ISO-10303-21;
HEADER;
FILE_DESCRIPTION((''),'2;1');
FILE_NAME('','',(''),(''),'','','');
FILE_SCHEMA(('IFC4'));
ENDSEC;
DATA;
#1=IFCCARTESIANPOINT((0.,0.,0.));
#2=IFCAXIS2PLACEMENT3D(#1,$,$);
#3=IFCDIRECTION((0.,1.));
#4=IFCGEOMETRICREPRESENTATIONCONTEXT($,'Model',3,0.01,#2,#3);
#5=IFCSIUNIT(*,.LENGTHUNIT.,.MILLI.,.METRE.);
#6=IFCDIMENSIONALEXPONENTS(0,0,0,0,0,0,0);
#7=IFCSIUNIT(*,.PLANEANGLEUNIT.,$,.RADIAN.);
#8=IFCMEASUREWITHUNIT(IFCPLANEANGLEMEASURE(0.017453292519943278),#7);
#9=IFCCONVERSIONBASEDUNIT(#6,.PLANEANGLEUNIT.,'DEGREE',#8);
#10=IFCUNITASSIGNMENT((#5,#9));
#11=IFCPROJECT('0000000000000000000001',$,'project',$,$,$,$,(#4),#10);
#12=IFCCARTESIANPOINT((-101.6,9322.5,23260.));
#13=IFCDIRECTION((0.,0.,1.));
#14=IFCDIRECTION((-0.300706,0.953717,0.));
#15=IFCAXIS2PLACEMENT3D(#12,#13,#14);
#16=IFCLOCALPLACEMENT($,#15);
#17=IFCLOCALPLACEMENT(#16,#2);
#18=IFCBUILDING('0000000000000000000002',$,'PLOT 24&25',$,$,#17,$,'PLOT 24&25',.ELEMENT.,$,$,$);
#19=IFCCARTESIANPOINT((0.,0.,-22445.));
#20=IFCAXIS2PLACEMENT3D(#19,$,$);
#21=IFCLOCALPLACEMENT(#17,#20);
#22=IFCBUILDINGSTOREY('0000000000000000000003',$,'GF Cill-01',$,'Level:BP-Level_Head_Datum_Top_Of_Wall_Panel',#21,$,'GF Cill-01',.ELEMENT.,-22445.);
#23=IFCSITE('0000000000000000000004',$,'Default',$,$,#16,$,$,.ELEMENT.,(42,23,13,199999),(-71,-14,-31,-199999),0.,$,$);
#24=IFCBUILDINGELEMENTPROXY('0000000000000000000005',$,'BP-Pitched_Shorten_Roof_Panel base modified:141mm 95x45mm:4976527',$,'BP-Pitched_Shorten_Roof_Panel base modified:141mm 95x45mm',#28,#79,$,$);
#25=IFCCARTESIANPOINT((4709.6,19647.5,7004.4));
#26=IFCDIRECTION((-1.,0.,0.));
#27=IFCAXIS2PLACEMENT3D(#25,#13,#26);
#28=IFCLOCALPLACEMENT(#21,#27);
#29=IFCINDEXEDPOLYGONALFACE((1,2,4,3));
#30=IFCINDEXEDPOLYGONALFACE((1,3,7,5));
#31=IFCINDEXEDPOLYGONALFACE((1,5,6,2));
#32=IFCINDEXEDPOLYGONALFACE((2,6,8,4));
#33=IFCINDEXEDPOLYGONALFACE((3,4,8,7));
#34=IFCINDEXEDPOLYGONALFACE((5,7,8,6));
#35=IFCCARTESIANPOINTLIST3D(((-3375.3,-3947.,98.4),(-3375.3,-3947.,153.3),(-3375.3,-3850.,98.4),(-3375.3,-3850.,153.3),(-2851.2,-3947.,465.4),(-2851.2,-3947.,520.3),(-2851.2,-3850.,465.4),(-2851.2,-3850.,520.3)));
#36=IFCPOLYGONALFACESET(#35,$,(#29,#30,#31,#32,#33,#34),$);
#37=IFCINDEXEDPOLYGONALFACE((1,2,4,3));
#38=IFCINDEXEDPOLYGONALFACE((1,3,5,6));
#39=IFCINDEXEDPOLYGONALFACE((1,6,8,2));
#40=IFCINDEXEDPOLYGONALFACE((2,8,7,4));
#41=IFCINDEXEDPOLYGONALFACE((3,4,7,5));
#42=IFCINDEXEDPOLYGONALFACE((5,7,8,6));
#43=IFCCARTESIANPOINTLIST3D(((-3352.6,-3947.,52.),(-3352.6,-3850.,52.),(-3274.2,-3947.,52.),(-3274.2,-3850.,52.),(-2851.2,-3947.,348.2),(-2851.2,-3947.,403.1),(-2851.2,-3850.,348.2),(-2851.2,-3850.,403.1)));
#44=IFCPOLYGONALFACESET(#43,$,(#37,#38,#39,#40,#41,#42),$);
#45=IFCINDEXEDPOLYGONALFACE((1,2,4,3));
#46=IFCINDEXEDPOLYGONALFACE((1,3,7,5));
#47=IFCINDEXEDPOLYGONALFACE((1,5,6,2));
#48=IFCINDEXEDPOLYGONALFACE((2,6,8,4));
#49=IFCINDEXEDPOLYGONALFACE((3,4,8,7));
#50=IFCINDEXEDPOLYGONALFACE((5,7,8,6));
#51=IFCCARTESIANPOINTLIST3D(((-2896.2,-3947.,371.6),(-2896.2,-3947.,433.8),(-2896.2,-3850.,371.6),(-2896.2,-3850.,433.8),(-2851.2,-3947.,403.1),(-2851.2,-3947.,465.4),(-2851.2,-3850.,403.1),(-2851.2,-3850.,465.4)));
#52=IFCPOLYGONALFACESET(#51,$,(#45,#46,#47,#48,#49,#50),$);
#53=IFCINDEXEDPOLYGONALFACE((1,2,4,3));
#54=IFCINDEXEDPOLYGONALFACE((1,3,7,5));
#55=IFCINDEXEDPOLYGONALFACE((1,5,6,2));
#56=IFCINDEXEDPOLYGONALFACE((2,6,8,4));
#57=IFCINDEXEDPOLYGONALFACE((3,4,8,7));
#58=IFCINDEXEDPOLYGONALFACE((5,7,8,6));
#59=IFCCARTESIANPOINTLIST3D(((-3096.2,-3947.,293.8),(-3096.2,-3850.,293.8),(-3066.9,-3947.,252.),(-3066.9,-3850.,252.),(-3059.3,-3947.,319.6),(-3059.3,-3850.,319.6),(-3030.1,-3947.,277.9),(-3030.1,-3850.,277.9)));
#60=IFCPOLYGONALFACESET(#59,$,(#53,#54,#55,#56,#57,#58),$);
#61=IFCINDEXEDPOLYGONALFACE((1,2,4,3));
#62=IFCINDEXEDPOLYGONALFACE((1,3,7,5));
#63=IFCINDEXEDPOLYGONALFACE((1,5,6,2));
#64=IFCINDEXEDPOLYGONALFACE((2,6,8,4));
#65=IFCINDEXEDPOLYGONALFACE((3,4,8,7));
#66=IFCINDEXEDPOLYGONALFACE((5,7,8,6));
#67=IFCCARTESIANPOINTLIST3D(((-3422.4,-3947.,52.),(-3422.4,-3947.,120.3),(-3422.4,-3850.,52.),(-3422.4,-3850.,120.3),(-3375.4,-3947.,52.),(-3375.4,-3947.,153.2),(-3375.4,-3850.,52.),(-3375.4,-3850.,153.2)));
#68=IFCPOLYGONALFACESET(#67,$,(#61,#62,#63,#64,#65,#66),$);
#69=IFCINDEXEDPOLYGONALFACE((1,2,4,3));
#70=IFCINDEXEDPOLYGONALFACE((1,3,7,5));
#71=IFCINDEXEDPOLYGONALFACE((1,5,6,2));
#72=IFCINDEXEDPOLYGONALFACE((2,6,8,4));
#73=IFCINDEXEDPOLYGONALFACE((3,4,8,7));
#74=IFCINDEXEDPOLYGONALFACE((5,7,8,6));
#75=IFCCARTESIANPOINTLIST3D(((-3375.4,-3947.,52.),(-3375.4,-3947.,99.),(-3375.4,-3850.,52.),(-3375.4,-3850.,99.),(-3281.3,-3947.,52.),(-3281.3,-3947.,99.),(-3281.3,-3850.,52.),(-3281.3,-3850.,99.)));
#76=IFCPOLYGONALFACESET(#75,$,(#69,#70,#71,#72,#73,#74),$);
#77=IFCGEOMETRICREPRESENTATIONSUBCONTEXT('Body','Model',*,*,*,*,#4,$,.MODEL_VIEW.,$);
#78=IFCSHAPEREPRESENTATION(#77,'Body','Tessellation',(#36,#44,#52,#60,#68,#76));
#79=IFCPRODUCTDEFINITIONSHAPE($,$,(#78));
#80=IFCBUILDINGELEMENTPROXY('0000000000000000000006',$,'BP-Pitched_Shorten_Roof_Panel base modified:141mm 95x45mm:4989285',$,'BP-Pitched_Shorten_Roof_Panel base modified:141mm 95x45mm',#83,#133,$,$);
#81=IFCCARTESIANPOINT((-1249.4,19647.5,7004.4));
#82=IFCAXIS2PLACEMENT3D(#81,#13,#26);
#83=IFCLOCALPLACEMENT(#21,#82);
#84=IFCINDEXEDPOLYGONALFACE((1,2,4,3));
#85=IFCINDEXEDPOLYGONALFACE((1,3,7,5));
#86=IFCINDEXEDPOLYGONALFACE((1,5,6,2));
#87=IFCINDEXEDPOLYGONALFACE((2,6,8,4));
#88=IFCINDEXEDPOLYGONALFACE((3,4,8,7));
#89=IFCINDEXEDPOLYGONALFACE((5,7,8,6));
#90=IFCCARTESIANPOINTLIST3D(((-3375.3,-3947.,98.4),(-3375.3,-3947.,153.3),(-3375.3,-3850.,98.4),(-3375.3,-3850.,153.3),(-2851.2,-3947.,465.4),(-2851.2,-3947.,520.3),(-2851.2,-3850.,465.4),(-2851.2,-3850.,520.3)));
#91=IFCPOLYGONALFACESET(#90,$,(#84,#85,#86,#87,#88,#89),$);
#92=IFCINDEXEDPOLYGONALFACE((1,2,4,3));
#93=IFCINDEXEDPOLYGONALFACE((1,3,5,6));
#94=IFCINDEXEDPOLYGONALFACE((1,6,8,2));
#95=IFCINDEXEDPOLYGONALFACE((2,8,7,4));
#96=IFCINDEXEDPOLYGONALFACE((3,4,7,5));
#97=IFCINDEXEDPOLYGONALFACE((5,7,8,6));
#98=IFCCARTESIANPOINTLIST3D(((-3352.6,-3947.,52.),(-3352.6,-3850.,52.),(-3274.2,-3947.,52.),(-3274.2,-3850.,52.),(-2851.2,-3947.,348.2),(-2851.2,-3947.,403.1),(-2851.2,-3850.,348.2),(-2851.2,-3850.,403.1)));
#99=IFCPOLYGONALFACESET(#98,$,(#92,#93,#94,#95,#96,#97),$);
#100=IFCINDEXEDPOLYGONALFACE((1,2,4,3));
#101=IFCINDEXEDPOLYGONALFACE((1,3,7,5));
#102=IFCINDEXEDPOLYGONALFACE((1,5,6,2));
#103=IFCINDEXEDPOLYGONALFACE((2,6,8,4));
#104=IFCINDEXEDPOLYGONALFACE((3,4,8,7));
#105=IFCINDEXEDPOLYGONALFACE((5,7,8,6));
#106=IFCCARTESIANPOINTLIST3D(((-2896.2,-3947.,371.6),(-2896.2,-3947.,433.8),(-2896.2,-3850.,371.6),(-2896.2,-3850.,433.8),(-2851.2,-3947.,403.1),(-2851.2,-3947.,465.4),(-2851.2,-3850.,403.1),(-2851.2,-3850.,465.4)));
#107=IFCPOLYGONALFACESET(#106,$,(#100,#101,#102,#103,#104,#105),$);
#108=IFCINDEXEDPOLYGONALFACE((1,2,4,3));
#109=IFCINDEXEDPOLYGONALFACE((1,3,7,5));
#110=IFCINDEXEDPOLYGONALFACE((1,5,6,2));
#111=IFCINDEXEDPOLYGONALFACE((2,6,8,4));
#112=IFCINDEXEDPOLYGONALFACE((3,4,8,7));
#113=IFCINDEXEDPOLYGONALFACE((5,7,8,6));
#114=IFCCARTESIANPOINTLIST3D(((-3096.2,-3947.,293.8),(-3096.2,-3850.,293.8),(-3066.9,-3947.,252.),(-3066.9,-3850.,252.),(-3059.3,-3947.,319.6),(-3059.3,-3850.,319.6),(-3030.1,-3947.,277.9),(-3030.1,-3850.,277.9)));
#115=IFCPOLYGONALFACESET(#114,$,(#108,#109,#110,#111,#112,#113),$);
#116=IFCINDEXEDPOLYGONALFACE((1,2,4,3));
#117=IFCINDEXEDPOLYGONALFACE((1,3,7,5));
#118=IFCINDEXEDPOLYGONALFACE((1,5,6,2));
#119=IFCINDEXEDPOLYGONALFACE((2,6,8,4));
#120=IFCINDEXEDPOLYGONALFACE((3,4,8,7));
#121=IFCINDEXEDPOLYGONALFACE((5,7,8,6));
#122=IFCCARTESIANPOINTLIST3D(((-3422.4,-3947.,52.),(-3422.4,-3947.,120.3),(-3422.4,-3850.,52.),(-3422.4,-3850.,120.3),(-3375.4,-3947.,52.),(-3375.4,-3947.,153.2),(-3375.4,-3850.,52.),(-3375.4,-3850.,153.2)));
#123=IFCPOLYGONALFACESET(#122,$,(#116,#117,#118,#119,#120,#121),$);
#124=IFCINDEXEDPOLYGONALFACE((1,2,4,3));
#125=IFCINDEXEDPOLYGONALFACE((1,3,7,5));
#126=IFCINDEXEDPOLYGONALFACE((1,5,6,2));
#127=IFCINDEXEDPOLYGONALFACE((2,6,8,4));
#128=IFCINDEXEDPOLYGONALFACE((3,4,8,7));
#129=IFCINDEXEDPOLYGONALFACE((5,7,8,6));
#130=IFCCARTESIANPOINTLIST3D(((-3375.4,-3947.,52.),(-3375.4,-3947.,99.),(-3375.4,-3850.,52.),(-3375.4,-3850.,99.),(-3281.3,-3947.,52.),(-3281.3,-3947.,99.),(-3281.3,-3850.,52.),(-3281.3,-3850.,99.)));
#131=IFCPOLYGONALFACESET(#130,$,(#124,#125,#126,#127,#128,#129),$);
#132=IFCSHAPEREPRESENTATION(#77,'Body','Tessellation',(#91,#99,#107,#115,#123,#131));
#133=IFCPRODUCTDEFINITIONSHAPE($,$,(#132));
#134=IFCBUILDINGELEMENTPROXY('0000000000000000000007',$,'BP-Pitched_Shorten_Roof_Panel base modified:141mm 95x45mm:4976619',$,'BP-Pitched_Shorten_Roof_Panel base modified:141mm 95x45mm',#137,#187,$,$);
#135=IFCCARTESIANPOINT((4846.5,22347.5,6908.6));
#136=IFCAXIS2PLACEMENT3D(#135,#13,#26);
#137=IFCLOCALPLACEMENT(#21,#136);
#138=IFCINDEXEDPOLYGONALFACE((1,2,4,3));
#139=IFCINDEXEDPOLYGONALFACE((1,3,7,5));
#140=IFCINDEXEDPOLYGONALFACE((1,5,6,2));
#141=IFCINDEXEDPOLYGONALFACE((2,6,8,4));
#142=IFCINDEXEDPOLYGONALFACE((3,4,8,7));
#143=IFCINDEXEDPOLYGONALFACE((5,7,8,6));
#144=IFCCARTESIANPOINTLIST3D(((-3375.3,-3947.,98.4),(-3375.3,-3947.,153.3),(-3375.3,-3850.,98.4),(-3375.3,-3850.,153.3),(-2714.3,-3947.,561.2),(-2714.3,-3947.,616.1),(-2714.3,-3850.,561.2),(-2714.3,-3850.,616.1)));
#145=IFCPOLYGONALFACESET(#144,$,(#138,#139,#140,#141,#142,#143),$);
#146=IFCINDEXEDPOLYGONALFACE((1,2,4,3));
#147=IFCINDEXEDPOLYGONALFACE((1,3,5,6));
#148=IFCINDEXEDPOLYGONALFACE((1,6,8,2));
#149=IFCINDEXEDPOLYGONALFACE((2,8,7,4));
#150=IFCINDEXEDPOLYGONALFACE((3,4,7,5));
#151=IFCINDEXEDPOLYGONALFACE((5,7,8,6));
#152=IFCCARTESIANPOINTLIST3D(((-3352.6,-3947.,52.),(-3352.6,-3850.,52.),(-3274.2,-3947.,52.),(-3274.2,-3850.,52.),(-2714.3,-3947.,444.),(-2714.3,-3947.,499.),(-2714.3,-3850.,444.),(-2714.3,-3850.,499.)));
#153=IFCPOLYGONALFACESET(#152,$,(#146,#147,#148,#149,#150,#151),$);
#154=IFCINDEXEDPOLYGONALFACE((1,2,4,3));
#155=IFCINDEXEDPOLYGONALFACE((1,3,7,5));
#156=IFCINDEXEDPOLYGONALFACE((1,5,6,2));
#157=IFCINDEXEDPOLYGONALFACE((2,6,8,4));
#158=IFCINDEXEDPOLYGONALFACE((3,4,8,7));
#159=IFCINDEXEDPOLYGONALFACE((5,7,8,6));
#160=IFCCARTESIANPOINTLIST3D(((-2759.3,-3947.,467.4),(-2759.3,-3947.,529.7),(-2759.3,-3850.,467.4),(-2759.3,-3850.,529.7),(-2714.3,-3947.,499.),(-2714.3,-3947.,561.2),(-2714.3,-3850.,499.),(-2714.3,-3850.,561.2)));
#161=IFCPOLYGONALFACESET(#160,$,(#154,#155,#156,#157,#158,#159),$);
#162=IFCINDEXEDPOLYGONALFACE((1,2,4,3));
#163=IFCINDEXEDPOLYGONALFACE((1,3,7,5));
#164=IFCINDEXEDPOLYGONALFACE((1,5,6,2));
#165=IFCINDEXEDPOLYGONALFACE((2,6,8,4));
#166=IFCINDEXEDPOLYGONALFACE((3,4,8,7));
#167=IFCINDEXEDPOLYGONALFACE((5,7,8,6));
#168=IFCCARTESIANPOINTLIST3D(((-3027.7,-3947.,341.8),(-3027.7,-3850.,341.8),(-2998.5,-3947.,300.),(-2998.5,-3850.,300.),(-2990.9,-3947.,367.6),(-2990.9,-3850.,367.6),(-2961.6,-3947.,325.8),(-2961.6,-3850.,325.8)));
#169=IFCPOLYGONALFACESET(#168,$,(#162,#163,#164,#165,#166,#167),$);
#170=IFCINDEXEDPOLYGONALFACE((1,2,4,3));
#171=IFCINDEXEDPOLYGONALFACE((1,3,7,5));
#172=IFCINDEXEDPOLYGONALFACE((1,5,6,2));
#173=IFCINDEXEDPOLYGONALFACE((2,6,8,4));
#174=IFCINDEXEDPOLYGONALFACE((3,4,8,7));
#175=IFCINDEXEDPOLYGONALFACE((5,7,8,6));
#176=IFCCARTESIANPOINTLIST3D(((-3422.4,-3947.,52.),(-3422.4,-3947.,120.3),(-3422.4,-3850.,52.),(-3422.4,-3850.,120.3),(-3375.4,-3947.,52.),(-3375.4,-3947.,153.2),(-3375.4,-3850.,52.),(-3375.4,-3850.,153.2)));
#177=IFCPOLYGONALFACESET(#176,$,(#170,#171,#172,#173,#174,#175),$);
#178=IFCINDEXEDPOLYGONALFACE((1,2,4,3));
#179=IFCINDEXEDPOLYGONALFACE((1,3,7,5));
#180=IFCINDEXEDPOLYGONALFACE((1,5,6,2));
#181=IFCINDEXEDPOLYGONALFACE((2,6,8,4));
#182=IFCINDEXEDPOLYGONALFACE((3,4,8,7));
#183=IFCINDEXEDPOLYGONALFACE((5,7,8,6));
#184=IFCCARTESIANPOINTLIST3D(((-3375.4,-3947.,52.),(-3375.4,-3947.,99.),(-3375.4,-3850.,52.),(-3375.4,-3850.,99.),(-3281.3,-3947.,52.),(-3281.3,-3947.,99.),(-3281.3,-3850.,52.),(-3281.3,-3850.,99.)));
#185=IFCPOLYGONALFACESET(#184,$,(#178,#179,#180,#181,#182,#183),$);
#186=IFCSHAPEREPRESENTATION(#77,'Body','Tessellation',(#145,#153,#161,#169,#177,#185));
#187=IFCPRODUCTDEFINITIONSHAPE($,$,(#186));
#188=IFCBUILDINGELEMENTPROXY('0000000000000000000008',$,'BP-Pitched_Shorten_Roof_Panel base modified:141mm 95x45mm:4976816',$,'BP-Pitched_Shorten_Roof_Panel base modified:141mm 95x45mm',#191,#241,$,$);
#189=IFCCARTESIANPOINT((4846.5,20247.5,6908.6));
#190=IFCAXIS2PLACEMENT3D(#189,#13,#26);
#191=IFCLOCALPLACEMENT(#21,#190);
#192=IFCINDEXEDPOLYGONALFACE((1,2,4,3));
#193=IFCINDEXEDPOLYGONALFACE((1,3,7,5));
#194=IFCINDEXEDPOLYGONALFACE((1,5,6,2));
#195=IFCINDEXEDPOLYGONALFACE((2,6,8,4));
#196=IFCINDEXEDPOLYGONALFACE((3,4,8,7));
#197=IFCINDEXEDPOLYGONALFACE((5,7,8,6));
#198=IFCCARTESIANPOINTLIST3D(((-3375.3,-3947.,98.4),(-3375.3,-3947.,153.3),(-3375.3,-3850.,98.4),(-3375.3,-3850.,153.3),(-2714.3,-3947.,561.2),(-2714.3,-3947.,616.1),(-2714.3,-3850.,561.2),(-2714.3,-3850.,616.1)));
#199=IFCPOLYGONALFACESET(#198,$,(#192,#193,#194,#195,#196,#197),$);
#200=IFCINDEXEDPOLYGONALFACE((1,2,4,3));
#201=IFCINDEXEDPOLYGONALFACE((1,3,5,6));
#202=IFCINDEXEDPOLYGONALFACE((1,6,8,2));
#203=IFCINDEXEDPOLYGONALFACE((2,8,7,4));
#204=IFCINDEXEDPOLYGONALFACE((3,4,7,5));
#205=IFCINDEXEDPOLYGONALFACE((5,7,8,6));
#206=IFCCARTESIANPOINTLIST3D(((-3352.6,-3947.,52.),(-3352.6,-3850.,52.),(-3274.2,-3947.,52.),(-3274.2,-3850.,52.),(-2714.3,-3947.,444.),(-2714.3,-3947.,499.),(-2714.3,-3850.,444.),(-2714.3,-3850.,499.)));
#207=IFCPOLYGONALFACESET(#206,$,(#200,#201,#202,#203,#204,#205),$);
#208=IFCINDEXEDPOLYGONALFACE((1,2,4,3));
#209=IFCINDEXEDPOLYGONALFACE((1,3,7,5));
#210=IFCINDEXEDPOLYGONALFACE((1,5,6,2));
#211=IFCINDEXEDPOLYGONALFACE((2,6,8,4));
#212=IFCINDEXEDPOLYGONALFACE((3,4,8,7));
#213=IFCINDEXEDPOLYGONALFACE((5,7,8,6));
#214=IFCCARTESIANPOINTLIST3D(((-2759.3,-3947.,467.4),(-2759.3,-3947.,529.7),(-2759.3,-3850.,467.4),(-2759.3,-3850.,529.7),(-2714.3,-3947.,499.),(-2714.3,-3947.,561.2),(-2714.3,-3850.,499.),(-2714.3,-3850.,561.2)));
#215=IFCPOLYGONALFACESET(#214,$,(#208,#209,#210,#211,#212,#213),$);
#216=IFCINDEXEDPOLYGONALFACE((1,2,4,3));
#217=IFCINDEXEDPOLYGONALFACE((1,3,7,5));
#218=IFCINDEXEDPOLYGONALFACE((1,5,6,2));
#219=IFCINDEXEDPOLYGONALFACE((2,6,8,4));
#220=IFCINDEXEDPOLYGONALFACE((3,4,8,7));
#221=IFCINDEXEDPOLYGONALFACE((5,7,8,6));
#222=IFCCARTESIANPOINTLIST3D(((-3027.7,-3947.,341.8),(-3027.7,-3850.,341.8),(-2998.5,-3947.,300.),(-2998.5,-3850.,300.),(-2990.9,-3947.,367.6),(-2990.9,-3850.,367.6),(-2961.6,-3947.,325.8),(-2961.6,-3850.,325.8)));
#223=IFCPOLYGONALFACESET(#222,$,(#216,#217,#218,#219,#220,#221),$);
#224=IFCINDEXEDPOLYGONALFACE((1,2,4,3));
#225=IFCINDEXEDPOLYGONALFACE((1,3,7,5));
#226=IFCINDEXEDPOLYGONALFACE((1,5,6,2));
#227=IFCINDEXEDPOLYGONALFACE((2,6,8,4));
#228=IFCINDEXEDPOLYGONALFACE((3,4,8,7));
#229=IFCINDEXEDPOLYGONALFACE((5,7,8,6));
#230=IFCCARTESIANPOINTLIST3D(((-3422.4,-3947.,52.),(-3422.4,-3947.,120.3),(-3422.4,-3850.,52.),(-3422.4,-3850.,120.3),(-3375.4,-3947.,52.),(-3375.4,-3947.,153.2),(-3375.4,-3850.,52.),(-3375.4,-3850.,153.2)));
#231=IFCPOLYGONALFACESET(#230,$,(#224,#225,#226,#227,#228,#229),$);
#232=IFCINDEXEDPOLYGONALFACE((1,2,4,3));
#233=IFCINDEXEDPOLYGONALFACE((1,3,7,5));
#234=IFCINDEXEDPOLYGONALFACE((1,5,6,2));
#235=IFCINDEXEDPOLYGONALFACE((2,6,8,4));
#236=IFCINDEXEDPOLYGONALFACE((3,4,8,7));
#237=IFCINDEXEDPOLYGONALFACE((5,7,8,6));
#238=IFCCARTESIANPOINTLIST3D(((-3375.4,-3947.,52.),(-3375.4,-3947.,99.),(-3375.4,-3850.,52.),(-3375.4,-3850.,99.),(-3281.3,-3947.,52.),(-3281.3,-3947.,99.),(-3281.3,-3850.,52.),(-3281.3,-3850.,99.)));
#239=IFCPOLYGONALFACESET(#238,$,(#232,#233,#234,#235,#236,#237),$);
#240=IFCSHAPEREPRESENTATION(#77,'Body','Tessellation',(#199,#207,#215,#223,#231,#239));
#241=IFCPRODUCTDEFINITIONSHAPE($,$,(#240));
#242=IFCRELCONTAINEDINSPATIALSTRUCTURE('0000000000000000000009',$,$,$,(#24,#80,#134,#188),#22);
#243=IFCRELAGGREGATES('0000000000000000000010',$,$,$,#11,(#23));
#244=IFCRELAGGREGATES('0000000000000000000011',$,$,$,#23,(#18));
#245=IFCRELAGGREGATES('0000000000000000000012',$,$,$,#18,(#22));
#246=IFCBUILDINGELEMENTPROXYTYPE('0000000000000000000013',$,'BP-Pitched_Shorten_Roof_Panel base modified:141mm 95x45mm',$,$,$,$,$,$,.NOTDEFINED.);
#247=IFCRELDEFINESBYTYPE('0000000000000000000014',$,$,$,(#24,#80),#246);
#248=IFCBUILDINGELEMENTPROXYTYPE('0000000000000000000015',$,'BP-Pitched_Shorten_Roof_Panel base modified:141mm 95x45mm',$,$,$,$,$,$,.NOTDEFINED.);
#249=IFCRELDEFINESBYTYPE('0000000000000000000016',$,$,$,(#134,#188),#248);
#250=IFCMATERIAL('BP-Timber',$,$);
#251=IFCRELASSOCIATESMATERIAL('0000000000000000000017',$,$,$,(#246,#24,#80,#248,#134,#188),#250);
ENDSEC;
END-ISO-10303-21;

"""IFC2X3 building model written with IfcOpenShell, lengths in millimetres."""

from ifc_helpers import new_model, entity, si_unit, converted_unit, direction, frame, frame_2d, origin, origin_2d_with_axis, place, context, subcontext, project, spatial, polyline, rectangle, outline, extrude, source, transform, mapped, material, type_object, type_shapes, element, save


model = new_model("IFC2X3")

# Units and contexts
model_context = context("Model", 3, precision=0.01, world=origin(), true_north=direction((0.0, 1.0)))
body_context = subcontext(model_context, "Body", "Model", "MODEL_VIEW")
ifc_project = project(units=[si_unit("LENGTHUNIT", "METRE", prefix="MILLI"), converted_unit("PLANEANGLEUNIT", "DEGREE", entity("IfcPlaneAngleMeasure", 0.017453292519943278), si_unit("PLANEANGLEUNIT", "RADIAN"), dimensions=[0, 0, 0, 0, 0, 0, 0])], contexts=[model_context])

# Site, building, storey
site_placement = place(None, frame((-101.6, 9322.5, 23260.0), z_axis=(0.0, 0.0, 1.0), x_axis=(-0.300706, 0.953717, 0.0)))
site = spatial("IfcSite", under=ifc_project, at=site_placement, Name="Default", CompositionType="ELEMENT", RefLatitude=(42, 23, 13, 199999), RefLongitude=(-71, -14, -31, -199999), RefElevation=0.0)
building_placement = place(site_placement, origin())
building = spatial("IfcBuilding", under=site, at=building_placement, Name="PLOT 24&25", LongName="PLOT 24&25", CompositionType="ELEMENT")
storey_placement = place(building_placement, frame((0.0, 0.0, -22445.0)))
storey = spatial("IfcBuildingStorey", under=building, at=storey_placement, Name="GF Cill-01", ObjectType="Level:BP-Level_Head_Datum_Top_Of_Wall_Panel", LongName="GF Cill-01", CompositionType="ELEMENT", Elevation=-22445.0)

# Shared definitions
ifc_material_1 = material(Name="BP-Timber")

# Building element proxies
building_element_proxy_type_1 = type_object("IfcBuildingElementProxyType", Name="BP-Pitched_Shorten_Roof_Panel base modified:141mm 95x45mm", PredefinedType="NOTDEFINED", material=ifc_material_1)
shared_shape_1 = source(origin(), body_context, "Body", "SweptSolid", [
    extrude(outline(polyline([(-211.0, -262.0), (-156.0, -262.0), (211.0, 262.0), (156.0, 262.0), (-211.0, -262.0)])), frame((-3113.3, -3947.0, 309.3), z_axis=(0.0, 1.0, 0.0), x_axis=(0.0, 0.0, -1.0)), (0.0, 0.0, 1.0), 97.0),
    extrude(outline(polyline([(-189.3, -231.1), (-134.3, -231.1), (161.8, 191.9), (161.8, 270.3), (-189.3, -231.1)])), frame((-3082.3, -3947.0, 213.8), z_axis=(0.0, 1.0, 0.0), x_axis=(0.0, 0.0, -1.0)), (0.0, 0.0, 1.0), 97.0),
    extrude(outline(polyline([(-9.6, -25.5), (45.3, -25.5), (9.6, 25.5), (-45.3, 25.5), (-9.6, -25.5)])), frame((-2873.7, -3947.0, 418.5), z_axis=(0.0, 1.0, 0.0), x_axis=(0.819152, 0.0, 0.573576)), (0.0, 0.0, 1.0), 97.0),
    extrude(rectangle(XDim=51.0, YDim=45.0, at=frame_2d((0.0, 0.0), x_axis=(1.0, 0.0))), frame((-3063.1, -3947.0, 285.8), z_axis=(0.0, 1.0, 0.0), x_axis=(0.573576, 0.0, -0.819152)), (0.0, 0.0, 1.0), 97.0),
    extrude(outline(polyline([(-58.9, -23.5), (42.4, -23.5), (42.4, 23.5), (-25.9, 23.5), (-58.9, -23.5)])), frame((-3398.9, -3947.0, 94.4), z_axis=(0.0, 1.0, 0.0), x_axis=(0.0, 0.0, -1.0)), (0.0, 0.0, 1.0), 97.0),
    extrude(rectangle(XDim=94.1, YDim=97.0, at=frame_2d((0.0, 0.0), x_axis=(1.0, 0.0))), frame((-3328.4, -3898.5, 52.0), z_axis=(0.0, 0.0, 1.0), x_axis=(-1.0, 0.0, 0.0)), (0.0, 0.0, 1.0), 47.0),
])
type_shapes(building_element_proxy_type_1, [shared_shape_1])
for number, where, z_axis, x_axis, name in (
    (1, (4709.6, 19647.5, 7004.4), (0.0, 0.0, 1.0), (-1.0, 0.0, 0.0), "BP-Pitched_Shorten_Roof_Panel base modified:141mm 95x45mm:4976527"),
    (2, (-1249.4, 19647.5, 7004.4), (0.0, 0.0, 1.0), (-1.0, 0.0, 0.0), "BP-Pitched_Shorten_Roof_Panel base modified:141mm 95x45mm:4989285"),
):
    element("IfcBuildingElementProxy", number, at=place(storey_placement, frame(where, z_axis=z_axis, x_axis=x_axis)), inside=storey, type_object=building_element_proxy_type_1, material=ifc_material_1, Name=name, ObjectType="BP-Pitched_Shorten_Roof_Panel base modified:141mm 95x45mm", context=body_context, shape_type="MappedRepresentation", body=[
        mapped(shared_shape_1, transform((0.0, 0.0, 0.0), scale=1.0)),
    ])
building_element_proxy_type_2 = type_object("IfcBuildingElementProxyType", Name="BP-Pitched_Shorten_Roof_Panel base modified:141mm 95x45mm", PredefinedType="NOTDEFINED", material=ifc_material_1)
shared_shape_2 = source(origin(), body_context, "Body", "SweptSolid", [
    extrude(outline(polyline([(-258.9, -330.5), (-204.0, -330.5), (258.9, 330.5), (204.0, 330.5), (-258.9, -330.5)])), frame((-3044.8, -3947.0, 357.3), z_axis=(0.0, 1.0, 0.0), x_axis=(0.0, 0.0, -1.0)), (0.0, 0.0, 1.0), 97.0),
    extrude(outline(polyline([(-237.2, -299.5), (-182.3, -299.5), (209.7, 260.3), (209.7, 338.8), (-237.2, -299.5)])), frame((-3013.9, -3947.0, 261.7), z_axis=(0.0, 1.0, 0.0), x_axis=(0.0, 0.0, -1.0)), (0.0, 0.0, 1.0), 97.0),
    extrude(outline(polyline([(-9.6, -25.5), (45.3, -25.5), (9.6, 25.5), (-45.3, 25.5), (-9.6, -25.5)])), frame((-2736.8, -3947.0, 514.3), z_axis=(0.0, 1.0, 0.0), x_axis=(0.819152, 0.0, 0.573576)), (0.0, 0.0, 1.0), 97.0),
    extrude(rectangle(XDim=51.0, YDim=45.0, at=origin_2d_with_axis()), frame((-2994.7, -3947.0, 333.8), z_axis=(0.0, 1.0, 0.0), x_axis=(0.573576, 0.0, -0.819152)), (0.0, 0.0, 1.0), 97.0),
    extrude(outline(polyline([(-58.9, -23.5), (42.4, -23.5), (42.4, 23.5), (-25.9, 23.5), (-58.9, -23.5)])), frame((-3398.9, -3947.0, 94.4), z_axis=(0.0, 1.0, 0.0), x_axis=(0.0, 0.0, -1.0)), (0.0, 0.0, 1.0), 97.0),
    extrude(rectangle(XDim=94.1, YDim=97.0, at=frame_2d((0.0, 0.0), x_axis=(1.0, 0.0))), frame((-3328.4, -3898.5, 52.0), z_axis=(0.0, 0.0, 1.0), x_axis=(-1.0, 0.0, 0.0)), (0.0, 0.0, 1.0), 47.0),
])
type_shapes(building_element_proxy_type_2, [shared_shape_2])
for number, where, z_axis, x_axis, name in (
    (3, (4846.5, 22347.5, 6908.6), (0.0, 0.0, 1.0), (-1.0, 0.0, 0.0), "BP-Pitched_Shorten_Roof_Panel base modified:141mm 95x45mm:4976619"),
    (4, (4846.5, 20247.5, 6908.6), (0.0, 0.0, 1.0), (-1.0, 0.0, 0.0), "BP-Pitched_Shorten_Roof_Panel base modified:141mm 95x45mm:4976816"),
):
    element("IfcBuildingElementProxy", number, at=place(storey_placement, frame(where, z_axis=z_axis, x_axis=x_axis)), inside=storey, type_object=building_element_proxy_type_2, material=ifc_material_1, Name=name, ObjectType="BP-Pitched_Shorten_Roof_Panel base modified:141mm 95x45mm", context=body_context, shape_type="MappedRepresentation", body=[
        mapped(shared_shape_2, transform((0.0, 0.0, 0.0), scale=1.0)),
    ])

save(model, "model.ifc")
